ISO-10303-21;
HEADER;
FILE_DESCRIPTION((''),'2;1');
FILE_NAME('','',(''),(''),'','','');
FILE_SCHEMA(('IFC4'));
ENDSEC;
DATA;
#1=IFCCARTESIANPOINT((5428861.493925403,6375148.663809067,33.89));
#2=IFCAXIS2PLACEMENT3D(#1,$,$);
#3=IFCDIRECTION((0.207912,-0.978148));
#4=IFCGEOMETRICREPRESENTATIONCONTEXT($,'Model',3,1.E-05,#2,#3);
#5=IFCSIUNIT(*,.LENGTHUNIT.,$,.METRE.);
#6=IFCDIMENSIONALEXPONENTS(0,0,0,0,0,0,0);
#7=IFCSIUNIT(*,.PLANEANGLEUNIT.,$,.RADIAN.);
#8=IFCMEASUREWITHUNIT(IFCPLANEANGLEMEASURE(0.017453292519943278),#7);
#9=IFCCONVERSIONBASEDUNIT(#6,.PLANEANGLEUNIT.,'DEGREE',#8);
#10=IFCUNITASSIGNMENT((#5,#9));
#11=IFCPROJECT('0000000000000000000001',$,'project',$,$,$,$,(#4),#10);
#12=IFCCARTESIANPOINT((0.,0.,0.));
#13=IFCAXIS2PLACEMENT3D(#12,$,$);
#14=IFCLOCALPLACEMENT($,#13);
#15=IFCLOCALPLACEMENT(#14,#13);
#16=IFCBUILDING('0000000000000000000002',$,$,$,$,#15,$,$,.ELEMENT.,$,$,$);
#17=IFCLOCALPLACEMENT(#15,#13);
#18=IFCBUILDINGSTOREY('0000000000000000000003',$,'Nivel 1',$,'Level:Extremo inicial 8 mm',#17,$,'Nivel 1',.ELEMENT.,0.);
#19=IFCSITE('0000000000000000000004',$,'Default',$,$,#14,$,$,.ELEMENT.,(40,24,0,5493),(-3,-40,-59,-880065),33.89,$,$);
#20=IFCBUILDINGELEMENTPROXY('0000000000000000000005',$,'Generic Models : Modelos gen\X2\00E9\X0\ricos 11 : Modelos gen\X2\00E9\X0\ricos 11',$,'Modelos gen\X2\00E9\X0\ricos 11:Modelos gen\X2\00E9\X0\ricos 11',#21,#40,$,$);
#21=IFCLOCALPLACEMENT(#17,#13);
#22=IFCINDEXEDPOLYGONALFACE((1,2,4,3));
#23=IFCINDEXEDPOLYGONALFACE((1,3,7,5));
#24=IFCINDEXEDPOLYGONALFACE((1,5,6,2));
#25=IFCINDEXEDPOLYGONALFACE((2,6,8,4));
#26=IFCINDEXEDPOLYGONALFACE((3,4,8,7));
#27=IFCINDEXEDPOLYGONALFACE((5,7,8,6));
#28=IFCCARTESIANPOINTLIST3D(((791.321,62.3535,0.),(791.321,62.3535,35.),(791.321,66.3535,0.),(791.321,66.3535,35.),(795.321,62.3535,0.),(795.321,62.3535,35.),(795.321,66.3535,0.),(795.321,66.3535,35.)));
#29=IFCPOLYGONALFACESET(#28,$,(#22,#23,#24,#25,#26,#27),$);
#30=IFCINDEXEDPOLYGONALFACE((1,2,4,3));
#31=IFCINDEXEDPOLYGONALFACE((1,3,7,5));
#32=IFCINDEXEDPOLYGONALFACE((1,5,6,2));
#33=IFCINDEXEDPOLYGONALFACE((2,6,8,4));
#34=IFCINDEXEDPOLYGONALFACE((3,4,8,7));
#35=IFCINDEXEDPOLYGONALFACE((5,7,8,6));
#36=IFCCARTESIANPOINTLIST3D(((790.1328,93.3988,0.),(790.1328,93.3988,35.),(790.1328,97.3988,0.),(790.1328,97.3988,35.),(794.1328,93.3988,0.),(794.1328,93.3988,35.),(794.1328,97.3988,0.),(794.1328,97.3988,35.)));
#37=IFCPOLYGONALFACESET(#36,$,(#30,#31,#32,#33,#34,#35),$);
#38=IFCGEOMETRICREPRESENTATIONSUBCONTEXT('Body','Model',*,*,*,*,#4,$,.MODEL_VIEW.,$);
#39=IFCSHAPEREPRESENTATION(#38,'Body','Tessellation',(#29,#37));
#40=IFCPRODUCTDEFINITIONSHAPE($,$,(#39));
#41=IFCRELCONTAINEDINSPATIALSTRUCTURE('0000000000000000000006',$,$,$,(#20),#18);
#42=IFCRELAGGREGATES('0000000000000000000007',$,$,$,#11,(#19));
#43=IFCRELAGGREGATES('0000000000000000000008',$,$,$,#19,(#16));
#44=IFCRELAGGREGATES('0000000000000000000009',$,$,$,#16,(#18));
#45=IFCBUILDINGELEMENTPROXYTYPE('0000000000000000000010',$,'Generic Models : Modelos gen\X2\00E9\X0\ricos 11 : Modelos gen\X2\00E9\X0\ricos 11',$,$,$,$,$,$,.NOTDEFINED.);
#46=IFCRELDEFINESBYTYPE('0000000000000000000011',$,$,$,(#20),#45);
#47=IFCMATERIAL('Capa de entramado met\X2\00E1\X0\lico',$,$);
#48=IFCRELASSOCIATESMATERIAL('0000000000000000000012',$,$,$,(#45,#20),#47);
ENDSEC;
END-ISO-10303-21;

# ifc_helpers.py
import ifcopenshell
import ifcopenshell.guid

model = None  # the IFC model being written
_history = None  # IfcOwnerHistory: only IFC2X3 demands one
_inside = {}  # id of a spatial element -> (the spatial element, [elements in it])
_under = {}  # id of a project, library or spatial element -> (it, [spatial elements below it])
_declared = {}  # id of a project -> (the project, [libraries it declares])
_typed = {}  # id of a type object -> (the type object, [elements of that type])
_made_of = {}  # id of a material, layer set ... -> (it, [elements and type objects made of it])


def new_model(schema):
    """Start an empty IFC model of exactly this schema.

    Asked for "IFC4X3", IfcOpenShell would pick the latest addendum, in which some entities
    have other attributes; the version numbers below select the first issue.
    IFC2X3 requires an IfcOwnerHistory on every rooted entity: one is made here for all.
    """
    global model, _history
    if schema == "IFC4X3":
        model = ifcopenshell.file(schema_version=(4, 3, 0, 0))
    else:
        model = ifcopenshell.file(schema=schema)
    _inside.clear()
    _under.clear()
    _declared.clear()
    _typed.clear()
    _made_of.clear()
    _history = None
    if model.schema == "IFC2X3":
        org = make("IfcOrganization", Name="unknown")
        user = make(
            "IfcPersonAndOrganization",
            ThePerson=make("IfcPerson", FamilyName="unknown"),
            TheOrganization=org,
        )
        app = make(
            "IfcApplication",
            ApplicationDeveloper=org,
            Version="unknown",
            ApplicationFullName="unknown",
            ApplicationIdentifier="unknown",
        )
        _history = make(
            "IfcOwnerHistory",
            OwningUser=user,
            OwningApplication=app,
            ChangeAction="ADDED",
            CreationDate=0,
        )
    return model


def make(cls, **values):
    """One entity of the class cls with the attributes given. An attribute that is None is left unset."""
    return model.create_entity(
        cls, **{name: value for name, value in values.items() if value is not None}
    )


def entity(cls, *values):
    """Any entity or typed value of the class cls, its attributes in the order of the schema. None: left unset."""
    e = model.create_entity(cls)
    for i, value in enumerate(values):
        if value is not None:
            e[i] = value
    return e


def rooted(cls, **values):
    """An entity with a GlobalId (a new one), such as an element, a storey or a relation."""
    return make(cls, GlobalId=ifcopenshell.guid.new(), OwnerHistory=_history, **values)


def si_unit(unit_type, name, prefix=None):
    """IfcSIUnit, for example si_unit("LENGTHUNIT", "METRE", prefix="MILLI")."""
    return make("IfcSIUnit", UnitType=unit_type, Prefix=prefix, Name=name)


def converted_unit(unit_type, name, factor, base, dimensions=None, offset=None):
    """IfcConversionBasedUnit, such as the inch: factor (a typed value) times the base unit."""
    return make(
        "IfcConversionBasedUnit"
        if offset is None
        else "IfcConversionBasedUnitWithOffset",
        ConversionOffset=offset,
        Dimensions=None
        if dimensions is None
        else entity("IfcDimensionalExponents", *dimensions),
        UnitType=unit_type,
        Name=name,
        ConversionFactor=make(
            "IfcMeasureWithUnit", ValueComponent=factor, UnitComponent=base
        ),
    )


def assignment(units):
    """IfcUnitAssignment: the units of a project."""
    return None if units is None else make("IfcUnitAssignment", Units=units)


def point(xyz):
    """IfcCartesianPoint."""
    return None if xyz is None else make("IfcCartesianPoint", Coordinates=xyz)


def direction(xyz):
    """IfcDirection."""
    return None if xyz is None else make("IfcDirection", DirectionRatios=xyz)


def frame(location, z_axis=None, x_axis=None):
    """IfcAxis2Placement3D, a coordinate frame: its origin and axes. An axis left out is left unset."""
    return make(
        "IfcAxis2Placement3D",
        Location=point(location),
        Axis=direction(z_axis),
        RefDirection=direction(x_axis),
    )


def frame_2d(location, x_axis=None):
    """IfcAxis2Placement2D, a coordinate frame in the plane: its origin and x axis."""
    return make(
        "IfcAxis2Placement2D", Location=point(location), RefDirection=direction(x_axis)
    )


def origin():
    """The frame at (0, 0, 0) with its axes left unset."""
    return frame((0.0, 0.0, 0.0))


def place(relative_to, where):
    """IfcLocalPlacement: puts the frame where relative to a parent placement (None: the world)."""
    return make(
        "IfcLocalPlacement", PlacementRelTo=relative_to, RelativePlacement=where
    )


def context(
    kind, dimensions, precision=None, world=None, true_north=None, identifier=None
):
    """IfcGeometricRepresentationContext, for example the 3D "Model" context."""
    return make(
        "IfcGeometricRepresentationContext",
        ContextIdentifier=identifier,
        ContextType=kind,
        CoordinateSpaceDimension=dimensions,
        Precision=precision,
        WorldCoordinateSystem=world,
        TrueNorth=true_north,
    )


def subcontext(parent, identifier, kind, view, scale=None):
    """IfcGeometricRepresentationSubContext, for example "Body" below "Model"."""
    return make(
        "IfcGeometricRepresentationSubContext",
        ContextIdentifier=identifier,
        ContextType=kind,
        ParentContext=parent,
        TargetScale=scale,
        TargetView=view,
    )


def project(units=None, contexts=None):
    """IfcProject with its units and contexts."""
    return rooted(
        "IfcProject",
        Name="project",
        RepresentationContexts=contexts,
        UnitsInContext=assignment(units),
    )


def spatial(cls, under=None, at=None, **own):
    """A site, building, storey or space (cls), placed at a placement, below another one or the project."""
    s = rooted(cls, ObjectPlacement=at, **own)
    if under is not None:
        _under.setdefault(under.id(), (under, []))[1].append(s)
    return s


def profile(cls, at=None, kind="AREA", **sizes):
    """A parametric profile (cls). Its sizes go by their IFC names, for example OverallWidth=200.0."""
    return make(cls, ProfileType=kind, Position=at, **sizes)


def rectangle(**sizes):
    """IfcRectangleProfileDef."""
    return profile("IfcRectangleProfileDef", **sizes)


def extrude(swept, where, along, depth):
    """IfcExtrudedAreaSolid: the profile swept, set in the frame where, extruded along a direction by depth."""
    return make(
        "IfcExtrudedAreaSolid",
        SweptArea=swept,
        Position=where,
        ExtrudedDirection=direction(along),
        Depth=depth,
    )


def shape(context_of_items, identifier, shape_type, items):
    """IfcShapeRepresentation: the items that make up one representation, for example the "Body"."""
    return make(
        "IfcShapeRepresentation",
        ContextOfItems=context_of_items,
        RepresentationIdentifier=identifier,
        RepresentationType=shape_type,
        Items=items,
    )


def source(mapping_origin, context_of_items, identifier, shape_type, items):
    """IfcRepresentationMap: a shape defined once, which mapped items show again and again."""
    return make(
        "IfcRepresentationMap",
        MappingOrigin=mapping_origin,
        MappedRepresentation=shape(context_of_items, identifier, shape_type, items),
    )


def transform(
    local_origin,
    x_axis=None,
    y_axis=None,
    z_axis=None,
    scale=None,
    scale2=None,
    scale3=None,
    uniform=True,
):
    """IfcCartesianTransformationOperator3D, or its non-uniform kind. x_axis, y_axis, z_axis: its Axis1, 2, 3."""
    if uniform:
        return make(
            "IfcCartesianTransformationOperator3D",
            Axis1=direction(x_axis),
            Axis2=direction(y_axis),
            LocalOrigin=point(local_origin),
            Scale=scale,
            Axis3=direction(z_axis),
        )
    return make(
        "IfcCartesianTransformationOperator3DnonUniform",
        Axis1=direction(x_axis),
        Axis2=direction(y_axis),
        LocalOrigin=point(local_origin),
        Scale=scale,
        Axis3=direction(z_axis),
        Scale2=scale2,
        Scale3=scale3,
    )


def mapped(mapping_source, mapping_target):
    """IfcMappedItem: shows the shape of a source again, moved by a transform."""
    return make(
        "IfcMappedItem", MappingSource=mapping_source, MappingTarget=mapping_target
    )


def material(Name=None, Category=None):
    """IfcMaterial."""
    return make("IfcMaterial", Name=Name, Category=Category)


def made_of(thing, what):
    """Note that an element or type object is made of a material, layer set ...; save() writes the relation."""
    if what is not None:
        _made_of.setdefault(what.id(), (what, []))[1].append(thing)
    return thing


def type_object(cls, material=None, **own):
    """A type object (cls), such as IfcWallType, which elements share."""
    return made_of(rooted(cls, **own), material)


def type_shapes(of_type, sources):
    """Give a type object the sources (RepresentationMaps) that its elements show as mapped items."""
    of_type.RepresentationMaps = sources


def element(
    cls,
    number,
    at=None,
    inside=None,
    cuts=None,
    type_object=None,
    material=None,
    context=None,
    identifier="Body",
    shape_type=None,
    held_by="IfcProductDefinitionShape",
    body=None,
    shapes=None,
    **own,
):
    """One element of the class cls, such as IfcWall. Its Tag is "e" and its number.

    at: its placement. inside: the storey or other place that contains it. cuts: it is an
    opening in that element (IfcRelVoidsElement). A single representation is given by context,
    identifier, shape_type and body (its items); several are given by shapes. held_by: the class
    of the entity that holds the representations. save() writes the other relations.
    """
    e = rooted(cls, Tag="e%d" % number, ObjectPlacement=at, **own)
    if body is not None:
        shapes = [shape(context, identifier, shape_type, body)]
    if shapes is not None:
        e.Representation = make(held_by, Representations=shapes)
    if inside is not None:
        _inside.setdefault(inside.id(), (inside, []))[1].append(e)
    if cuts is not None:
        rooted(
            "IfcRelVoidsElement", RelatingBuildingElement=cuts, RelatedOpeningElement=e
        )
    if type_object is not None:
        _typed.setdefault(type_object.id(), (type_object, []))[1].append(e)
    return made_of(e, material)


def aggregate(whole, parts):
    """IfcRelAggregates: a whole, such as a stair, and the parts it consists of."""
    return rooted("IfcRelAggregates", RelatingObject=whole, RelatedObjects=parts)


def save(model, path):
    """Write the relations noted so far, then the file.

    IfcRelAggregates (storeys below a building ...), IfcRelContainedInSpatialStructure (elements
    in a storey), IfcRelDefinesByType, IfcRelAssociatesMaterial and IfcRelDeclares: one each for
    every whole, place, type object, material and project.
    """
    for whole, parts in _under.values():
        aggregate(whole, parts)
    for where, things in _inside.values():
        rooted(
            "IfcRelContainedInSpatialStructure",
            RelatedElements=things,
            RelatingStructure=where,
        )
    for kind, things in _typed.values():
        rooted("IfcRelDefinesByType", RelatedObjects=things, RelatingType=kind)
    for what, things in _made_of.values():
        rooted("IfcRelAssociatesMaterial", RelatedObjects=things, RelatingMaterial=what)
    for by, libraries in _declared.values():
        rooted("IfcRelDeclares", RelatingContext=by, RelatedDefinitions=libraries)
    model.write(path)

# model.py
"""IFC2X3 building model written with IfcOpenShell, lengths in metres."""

from ifc_helpers import new_model, entity, si_unit, converted_unit, direction, frame, frame_2d, origin, place, context, subcontext, project, spatial, rectangle, extrude, source, transform, mapped, material, type_object, type_shapes, element, save


model = new_model("IFC2X3")

# Units and contexts
model_context = context("Model", 3, precision=1e-05, world=frame((5428861.493925403, 6375148.663809067, 33.89)), true_north=direction((0.207912, -0.978148)))
body_context = subcontext(model_context, "Body", "Model", "MODEL_VIEW")
ifc_project = project(units=[si_unit("LENGTHUNIT", "METRE"), converted_unit("PLANEANGLEUNIT", "DEGREE", entity("IfcPlaneAngleMeasure", 0.017453292519943278), si_unit("PLANEANGLEUNIT", "RADIAN"), dimensions=[0, 0, 0, 0, 0, 0, 0])], contexts=[model_context])

# Site, building, storey
site_placement = place(None, origin())
site = spatial("IfcSite", under=ifc_project, at=site_placement, Name="Default", CompositionType="ELEMENT", RefLatitude=(40, 24, 0, 5493), RefLongitude=(-3, -40, -59, -880065), RefElevation=33.89)
building_placement = place(site_placement, origin())
building = spatial("IfcBuilding", under=site, at=building_placement, CompositionType="ELEMENT")
storey_placement = place(building_placement, origin())
storey = spatial("IfcBuildingStorey", under=building, at=storey_placement, Name="Nivel 1", ObjectType="Level:Extremo inicial 8 mm", LongName="Nivel 1", CompositionType="ELEMENT", Elevation=0.0)

# Building element proxy
ifc_material_1 = material(Name="Capa de entramado metálico")
building_element_proxy_type_1 = type_object("IfcBuildingElementProxyType", Name="Generic Models : Modelos genéricos 11 : Modelos genéricos 11", PredefinedType="NOTDEFINED", material=ifc_material_1)
shared_shape_1 = source(origin(), body_context, "Body", "SweptSolid", [
    extrude(rectangle(XDim=4.0, YDim=4.0, at=frame_2d((0.0, 0.0), x_axis=(1.0, 0.0))), frame((793.321, 64.3535, 0.0), z_axis=(0.0, 0.0, 1.0), x_axis=(0.0, -1.0, 0.0)), (0.0, 0.0, 1.0), 35.0),
    extrude(rectangle(XDim=4.0, YDim=4.0, at=frame_2d((0.0, 0.0), x_axis=(1.0, 0.0))), frame((792.1328, 95.3988, 0.0), z_axis=(0.0, 0.0, 1.0), x_axis=(0.0, -1.0, 0.0)), (0.0, 0.0, 1.0), 35.0),
])
type_shapes(building_element_proxy_type_1, [shared_shape_1])
proxy_1_placement = place(storey_placement, origin())
element("IfcBuildingElementProxy", 1, at=proxy_1_placement, inside=storey, type_object=building_element_proxy_type_1, material=ifc_material_1, Name="Generic Models : Modelos genéricos 11 : Modelos genéricos 11", ObjectType="Modelos genéricos 11:Modelos genéricos 11", context=body_context, shape_type="MappedRepresentation", body=[
    mapped(shared_shape_1, transform((0.0, 0.0, 0.0), scale=1.0)),
])

save(model, "model.ifc")
